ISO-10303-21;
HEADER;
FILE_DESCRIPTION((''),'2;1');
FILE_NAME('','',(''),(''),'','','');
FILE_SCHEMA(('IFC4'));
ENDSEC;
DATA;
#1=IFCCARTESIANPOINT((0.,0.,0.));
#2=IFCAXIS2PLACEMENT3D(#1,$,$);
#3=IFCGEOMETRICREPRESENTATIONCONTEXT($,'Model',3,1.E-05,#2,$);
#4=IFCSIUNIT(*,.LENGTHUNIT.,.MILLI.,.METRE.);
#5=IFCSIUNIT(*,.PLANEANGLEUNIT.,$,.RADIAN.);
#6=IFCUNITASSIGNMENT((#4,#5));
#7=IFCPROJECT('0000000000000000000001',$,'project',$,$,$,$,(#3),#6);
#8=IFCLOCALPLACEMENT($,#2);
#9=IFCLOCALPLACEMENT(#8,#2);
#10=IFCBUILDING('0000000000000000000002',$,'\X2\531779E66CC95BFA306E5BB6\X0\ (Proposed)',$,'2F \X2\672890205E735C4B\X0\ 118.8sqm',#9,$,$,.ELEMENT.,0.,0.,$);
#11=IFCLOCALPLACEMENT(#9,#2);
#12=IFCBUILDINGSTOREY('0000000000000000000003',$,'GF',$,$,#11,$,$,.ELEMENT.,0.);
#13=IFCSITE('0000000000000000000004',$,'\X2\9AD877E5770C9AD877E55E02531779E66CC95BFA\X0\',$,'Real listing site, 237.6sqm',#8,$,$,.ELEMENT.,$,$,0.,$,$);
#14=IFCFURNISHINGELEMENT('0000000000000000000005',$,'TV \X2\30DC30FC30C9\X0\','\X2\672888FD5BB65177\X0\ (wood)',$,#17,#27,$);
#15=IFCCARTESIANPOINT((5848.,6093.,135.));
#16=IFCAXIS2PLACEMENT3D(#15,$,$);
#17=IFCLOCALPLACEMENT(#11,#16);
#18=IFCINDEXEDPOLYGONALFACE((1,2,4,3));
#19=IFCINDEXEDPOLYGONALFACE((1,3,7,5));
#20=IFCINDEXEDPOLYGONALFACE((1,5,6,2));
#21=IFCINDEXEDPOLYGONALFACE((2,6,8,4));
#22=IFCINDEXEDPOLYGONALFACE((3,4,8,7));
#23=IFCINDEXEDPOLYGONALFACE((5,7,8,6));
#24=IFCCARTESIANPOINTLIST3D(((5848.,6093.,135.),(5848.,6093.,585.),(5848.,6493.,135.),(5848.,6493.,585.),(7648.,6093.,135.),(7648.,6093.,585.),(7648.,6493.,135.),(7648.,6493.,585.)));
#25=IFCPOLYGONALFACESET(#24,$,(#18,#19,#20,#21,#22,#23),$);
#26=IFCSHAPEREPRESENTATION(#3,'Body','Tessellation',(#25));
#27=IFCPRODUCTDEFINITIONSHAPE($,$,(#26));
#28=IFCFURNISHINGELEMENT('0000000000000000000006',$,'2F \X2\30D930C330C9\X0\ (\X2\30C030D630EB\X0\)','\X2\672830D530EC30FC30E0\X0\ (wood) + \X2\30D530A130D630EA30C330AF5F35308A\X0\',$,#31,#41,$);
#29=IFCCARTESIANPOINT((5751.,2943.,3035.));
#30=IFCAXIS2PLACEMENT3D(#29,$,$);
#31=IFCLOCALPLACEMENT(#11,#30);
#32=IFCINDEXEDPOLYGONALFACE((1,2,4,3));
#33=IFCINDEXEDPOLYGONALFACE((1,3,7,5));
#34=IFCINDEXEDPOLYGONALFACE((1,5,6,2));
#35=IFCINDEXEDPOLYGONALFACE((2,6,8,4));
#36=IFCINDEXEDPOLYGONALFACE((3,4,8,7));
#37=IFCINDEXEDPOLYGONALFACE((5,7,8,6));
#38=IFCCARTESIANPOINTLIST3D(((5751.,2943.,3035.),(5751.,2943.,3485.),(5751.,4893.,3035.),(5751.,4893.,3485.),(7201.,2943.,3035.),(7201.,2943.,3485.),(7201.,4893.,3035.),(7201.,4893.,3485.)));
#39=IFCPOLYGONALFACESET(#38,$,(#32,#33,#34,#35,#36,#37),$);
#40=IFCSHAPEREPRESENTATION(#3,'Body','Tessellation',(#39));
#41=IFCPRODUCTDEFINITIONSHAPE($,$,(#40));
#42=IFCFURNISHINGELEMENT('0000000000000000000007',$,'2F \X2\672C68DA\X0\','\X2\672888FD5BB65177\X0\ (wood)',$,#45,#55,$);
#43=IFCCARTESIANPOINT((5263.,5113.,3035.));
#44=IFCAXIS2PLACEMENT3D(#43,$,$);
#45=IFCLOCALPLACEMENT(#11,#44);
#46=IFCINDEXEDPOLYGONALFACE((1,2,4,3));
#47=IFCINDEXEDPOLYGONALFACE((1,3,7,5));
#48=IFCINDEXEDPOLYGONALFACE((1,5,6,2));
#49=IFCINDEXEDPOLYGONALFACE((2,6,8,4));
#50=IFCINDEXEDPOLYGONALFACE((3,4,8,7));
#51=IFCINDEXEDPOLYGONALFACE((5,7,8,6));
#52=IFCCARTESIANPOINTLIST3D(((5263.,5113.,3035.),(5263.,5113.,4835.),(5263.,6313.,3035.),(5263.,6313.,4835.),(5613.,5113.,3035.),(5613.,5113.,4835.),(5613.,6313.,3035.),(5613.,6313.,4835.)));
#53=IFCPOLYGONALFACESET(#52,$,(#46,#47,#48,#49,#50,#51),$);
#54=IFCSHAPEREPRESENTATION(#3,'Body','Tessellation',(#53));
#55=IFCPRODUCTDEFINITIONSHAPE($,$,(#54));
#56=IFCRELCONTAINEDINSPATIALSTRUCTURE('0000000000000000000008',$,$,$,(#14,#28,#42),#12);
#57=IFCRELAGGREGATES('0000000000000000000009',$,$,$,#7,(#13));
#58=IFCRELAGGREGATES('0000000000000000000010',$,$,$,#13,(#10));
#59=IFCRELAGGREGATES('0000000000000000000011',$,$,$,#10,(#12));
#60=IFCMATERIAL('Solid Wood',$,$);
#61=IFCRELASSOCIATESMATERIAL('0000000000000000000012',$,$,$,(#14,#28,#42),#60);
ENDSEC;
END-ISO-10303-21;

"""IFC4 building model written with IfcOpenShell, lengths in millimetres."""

from ifc_helpers import new_model, si_unit, frame, frame_2d, origin, place, context, project, spatial, rectangle, extrude, material, element, save


model = new_model("IFC4")

# Units and contexts
model_context = context("Model", 3, precision=1e-05, world=origin())
ifc_project = project(units=[si_unit("LENGTHUNIT", "METRE", prefix="MILLI"), si_unit("PLANEANGLEUNIT", "RADIAN")], contexts=[model_context])

# Site, building, storey
site_placement = place(None, origin())
site = spatial("IfcSite", under=ifc_project, at=site_placement, Name="高知県高知市北秦泉寺", ObjectType="Real listing site, 237.6sqm", CompositionType="ELEMENT", RefElevation=0.0)
building_placement = place(site_placement, origin())
building = spatial("IfcBuilding", under=site, at=building_placement, Name="北秦泉寺の家 (Proposed)", ObjectType="2F 木造平屋 118.8sqm", CompositionType="ELEMENT", ElevationOfRefHeight=0.0, ElevationOfTerrain=0.0)
storey_placement = place(building_placement, origin())
storey = spatial("IfcBuildingStorey", under=building, at=storey_placement, Name="GF", CompositionType="ELEMENT", Elevation=0.0)

# Shared definitions
ifc_material_1 = material(Name="Solid Wood")

# Furnishing elements
furnishing_1_placement = place(storey_placement, frame((5848.0, 6093.0, 135.0)))
element("IfcFurnishingElement", 1, at=furnishing_1_placement, inside=storey, material=ifc_material_1, Name="TV ボード", Description="木製家具 (wood)", context=model_context, shape_type="SweptSolid", body=[
    extrude(rectangle(XDim=1800.0, YDim=400.0, at=frame_2d((900.0, 200.0))), frame((5848.0, 6093.0, 135.0)), (0.0, 0.0, 1.0), 450.0),
])
furnishing_2_placement = place(storey_placement, frame((5751.0, 2943.0, 3035.0)))
element("IfcFurnishingElement", 2, at=furnishing_2_placement, inside=storey, material=ifc_material_1, Name="2F ベッド (ダブル)", Description="木フレーム (wood) + ファブリック張り", context=model_context, shape_type="SweptSolid", body=[
    extrude(rectangle(XDim=1450.0, YDim=1950.0, at=frame_2d((725.0, 975.0))), frame((5751.0, 2943.0, 3035.0)), (0.0, 0.0, 1.0), 450.0),
])
furnishing_3_placement = place(storey_placement, frame((5263.0, 5113.0, 3035.0)))
element("IfcFurnishingElement", 3, at=furnishing_3_placement, inside=storey, material=ifc_material_1, Name="2F 本棚", Description="木製家具 (wood)", context=model_context, shape_type="SweptSolid", body=[
    extrude(rectangle(XDim=350.0, YDim=1200.0, at=frame_2d((175.0, 600.0))), frame((5263.0, 5113.0, 3035.0)), (0.0, 0.0, 1.0), 1800.0),
])

save(model, "model.ifc")
